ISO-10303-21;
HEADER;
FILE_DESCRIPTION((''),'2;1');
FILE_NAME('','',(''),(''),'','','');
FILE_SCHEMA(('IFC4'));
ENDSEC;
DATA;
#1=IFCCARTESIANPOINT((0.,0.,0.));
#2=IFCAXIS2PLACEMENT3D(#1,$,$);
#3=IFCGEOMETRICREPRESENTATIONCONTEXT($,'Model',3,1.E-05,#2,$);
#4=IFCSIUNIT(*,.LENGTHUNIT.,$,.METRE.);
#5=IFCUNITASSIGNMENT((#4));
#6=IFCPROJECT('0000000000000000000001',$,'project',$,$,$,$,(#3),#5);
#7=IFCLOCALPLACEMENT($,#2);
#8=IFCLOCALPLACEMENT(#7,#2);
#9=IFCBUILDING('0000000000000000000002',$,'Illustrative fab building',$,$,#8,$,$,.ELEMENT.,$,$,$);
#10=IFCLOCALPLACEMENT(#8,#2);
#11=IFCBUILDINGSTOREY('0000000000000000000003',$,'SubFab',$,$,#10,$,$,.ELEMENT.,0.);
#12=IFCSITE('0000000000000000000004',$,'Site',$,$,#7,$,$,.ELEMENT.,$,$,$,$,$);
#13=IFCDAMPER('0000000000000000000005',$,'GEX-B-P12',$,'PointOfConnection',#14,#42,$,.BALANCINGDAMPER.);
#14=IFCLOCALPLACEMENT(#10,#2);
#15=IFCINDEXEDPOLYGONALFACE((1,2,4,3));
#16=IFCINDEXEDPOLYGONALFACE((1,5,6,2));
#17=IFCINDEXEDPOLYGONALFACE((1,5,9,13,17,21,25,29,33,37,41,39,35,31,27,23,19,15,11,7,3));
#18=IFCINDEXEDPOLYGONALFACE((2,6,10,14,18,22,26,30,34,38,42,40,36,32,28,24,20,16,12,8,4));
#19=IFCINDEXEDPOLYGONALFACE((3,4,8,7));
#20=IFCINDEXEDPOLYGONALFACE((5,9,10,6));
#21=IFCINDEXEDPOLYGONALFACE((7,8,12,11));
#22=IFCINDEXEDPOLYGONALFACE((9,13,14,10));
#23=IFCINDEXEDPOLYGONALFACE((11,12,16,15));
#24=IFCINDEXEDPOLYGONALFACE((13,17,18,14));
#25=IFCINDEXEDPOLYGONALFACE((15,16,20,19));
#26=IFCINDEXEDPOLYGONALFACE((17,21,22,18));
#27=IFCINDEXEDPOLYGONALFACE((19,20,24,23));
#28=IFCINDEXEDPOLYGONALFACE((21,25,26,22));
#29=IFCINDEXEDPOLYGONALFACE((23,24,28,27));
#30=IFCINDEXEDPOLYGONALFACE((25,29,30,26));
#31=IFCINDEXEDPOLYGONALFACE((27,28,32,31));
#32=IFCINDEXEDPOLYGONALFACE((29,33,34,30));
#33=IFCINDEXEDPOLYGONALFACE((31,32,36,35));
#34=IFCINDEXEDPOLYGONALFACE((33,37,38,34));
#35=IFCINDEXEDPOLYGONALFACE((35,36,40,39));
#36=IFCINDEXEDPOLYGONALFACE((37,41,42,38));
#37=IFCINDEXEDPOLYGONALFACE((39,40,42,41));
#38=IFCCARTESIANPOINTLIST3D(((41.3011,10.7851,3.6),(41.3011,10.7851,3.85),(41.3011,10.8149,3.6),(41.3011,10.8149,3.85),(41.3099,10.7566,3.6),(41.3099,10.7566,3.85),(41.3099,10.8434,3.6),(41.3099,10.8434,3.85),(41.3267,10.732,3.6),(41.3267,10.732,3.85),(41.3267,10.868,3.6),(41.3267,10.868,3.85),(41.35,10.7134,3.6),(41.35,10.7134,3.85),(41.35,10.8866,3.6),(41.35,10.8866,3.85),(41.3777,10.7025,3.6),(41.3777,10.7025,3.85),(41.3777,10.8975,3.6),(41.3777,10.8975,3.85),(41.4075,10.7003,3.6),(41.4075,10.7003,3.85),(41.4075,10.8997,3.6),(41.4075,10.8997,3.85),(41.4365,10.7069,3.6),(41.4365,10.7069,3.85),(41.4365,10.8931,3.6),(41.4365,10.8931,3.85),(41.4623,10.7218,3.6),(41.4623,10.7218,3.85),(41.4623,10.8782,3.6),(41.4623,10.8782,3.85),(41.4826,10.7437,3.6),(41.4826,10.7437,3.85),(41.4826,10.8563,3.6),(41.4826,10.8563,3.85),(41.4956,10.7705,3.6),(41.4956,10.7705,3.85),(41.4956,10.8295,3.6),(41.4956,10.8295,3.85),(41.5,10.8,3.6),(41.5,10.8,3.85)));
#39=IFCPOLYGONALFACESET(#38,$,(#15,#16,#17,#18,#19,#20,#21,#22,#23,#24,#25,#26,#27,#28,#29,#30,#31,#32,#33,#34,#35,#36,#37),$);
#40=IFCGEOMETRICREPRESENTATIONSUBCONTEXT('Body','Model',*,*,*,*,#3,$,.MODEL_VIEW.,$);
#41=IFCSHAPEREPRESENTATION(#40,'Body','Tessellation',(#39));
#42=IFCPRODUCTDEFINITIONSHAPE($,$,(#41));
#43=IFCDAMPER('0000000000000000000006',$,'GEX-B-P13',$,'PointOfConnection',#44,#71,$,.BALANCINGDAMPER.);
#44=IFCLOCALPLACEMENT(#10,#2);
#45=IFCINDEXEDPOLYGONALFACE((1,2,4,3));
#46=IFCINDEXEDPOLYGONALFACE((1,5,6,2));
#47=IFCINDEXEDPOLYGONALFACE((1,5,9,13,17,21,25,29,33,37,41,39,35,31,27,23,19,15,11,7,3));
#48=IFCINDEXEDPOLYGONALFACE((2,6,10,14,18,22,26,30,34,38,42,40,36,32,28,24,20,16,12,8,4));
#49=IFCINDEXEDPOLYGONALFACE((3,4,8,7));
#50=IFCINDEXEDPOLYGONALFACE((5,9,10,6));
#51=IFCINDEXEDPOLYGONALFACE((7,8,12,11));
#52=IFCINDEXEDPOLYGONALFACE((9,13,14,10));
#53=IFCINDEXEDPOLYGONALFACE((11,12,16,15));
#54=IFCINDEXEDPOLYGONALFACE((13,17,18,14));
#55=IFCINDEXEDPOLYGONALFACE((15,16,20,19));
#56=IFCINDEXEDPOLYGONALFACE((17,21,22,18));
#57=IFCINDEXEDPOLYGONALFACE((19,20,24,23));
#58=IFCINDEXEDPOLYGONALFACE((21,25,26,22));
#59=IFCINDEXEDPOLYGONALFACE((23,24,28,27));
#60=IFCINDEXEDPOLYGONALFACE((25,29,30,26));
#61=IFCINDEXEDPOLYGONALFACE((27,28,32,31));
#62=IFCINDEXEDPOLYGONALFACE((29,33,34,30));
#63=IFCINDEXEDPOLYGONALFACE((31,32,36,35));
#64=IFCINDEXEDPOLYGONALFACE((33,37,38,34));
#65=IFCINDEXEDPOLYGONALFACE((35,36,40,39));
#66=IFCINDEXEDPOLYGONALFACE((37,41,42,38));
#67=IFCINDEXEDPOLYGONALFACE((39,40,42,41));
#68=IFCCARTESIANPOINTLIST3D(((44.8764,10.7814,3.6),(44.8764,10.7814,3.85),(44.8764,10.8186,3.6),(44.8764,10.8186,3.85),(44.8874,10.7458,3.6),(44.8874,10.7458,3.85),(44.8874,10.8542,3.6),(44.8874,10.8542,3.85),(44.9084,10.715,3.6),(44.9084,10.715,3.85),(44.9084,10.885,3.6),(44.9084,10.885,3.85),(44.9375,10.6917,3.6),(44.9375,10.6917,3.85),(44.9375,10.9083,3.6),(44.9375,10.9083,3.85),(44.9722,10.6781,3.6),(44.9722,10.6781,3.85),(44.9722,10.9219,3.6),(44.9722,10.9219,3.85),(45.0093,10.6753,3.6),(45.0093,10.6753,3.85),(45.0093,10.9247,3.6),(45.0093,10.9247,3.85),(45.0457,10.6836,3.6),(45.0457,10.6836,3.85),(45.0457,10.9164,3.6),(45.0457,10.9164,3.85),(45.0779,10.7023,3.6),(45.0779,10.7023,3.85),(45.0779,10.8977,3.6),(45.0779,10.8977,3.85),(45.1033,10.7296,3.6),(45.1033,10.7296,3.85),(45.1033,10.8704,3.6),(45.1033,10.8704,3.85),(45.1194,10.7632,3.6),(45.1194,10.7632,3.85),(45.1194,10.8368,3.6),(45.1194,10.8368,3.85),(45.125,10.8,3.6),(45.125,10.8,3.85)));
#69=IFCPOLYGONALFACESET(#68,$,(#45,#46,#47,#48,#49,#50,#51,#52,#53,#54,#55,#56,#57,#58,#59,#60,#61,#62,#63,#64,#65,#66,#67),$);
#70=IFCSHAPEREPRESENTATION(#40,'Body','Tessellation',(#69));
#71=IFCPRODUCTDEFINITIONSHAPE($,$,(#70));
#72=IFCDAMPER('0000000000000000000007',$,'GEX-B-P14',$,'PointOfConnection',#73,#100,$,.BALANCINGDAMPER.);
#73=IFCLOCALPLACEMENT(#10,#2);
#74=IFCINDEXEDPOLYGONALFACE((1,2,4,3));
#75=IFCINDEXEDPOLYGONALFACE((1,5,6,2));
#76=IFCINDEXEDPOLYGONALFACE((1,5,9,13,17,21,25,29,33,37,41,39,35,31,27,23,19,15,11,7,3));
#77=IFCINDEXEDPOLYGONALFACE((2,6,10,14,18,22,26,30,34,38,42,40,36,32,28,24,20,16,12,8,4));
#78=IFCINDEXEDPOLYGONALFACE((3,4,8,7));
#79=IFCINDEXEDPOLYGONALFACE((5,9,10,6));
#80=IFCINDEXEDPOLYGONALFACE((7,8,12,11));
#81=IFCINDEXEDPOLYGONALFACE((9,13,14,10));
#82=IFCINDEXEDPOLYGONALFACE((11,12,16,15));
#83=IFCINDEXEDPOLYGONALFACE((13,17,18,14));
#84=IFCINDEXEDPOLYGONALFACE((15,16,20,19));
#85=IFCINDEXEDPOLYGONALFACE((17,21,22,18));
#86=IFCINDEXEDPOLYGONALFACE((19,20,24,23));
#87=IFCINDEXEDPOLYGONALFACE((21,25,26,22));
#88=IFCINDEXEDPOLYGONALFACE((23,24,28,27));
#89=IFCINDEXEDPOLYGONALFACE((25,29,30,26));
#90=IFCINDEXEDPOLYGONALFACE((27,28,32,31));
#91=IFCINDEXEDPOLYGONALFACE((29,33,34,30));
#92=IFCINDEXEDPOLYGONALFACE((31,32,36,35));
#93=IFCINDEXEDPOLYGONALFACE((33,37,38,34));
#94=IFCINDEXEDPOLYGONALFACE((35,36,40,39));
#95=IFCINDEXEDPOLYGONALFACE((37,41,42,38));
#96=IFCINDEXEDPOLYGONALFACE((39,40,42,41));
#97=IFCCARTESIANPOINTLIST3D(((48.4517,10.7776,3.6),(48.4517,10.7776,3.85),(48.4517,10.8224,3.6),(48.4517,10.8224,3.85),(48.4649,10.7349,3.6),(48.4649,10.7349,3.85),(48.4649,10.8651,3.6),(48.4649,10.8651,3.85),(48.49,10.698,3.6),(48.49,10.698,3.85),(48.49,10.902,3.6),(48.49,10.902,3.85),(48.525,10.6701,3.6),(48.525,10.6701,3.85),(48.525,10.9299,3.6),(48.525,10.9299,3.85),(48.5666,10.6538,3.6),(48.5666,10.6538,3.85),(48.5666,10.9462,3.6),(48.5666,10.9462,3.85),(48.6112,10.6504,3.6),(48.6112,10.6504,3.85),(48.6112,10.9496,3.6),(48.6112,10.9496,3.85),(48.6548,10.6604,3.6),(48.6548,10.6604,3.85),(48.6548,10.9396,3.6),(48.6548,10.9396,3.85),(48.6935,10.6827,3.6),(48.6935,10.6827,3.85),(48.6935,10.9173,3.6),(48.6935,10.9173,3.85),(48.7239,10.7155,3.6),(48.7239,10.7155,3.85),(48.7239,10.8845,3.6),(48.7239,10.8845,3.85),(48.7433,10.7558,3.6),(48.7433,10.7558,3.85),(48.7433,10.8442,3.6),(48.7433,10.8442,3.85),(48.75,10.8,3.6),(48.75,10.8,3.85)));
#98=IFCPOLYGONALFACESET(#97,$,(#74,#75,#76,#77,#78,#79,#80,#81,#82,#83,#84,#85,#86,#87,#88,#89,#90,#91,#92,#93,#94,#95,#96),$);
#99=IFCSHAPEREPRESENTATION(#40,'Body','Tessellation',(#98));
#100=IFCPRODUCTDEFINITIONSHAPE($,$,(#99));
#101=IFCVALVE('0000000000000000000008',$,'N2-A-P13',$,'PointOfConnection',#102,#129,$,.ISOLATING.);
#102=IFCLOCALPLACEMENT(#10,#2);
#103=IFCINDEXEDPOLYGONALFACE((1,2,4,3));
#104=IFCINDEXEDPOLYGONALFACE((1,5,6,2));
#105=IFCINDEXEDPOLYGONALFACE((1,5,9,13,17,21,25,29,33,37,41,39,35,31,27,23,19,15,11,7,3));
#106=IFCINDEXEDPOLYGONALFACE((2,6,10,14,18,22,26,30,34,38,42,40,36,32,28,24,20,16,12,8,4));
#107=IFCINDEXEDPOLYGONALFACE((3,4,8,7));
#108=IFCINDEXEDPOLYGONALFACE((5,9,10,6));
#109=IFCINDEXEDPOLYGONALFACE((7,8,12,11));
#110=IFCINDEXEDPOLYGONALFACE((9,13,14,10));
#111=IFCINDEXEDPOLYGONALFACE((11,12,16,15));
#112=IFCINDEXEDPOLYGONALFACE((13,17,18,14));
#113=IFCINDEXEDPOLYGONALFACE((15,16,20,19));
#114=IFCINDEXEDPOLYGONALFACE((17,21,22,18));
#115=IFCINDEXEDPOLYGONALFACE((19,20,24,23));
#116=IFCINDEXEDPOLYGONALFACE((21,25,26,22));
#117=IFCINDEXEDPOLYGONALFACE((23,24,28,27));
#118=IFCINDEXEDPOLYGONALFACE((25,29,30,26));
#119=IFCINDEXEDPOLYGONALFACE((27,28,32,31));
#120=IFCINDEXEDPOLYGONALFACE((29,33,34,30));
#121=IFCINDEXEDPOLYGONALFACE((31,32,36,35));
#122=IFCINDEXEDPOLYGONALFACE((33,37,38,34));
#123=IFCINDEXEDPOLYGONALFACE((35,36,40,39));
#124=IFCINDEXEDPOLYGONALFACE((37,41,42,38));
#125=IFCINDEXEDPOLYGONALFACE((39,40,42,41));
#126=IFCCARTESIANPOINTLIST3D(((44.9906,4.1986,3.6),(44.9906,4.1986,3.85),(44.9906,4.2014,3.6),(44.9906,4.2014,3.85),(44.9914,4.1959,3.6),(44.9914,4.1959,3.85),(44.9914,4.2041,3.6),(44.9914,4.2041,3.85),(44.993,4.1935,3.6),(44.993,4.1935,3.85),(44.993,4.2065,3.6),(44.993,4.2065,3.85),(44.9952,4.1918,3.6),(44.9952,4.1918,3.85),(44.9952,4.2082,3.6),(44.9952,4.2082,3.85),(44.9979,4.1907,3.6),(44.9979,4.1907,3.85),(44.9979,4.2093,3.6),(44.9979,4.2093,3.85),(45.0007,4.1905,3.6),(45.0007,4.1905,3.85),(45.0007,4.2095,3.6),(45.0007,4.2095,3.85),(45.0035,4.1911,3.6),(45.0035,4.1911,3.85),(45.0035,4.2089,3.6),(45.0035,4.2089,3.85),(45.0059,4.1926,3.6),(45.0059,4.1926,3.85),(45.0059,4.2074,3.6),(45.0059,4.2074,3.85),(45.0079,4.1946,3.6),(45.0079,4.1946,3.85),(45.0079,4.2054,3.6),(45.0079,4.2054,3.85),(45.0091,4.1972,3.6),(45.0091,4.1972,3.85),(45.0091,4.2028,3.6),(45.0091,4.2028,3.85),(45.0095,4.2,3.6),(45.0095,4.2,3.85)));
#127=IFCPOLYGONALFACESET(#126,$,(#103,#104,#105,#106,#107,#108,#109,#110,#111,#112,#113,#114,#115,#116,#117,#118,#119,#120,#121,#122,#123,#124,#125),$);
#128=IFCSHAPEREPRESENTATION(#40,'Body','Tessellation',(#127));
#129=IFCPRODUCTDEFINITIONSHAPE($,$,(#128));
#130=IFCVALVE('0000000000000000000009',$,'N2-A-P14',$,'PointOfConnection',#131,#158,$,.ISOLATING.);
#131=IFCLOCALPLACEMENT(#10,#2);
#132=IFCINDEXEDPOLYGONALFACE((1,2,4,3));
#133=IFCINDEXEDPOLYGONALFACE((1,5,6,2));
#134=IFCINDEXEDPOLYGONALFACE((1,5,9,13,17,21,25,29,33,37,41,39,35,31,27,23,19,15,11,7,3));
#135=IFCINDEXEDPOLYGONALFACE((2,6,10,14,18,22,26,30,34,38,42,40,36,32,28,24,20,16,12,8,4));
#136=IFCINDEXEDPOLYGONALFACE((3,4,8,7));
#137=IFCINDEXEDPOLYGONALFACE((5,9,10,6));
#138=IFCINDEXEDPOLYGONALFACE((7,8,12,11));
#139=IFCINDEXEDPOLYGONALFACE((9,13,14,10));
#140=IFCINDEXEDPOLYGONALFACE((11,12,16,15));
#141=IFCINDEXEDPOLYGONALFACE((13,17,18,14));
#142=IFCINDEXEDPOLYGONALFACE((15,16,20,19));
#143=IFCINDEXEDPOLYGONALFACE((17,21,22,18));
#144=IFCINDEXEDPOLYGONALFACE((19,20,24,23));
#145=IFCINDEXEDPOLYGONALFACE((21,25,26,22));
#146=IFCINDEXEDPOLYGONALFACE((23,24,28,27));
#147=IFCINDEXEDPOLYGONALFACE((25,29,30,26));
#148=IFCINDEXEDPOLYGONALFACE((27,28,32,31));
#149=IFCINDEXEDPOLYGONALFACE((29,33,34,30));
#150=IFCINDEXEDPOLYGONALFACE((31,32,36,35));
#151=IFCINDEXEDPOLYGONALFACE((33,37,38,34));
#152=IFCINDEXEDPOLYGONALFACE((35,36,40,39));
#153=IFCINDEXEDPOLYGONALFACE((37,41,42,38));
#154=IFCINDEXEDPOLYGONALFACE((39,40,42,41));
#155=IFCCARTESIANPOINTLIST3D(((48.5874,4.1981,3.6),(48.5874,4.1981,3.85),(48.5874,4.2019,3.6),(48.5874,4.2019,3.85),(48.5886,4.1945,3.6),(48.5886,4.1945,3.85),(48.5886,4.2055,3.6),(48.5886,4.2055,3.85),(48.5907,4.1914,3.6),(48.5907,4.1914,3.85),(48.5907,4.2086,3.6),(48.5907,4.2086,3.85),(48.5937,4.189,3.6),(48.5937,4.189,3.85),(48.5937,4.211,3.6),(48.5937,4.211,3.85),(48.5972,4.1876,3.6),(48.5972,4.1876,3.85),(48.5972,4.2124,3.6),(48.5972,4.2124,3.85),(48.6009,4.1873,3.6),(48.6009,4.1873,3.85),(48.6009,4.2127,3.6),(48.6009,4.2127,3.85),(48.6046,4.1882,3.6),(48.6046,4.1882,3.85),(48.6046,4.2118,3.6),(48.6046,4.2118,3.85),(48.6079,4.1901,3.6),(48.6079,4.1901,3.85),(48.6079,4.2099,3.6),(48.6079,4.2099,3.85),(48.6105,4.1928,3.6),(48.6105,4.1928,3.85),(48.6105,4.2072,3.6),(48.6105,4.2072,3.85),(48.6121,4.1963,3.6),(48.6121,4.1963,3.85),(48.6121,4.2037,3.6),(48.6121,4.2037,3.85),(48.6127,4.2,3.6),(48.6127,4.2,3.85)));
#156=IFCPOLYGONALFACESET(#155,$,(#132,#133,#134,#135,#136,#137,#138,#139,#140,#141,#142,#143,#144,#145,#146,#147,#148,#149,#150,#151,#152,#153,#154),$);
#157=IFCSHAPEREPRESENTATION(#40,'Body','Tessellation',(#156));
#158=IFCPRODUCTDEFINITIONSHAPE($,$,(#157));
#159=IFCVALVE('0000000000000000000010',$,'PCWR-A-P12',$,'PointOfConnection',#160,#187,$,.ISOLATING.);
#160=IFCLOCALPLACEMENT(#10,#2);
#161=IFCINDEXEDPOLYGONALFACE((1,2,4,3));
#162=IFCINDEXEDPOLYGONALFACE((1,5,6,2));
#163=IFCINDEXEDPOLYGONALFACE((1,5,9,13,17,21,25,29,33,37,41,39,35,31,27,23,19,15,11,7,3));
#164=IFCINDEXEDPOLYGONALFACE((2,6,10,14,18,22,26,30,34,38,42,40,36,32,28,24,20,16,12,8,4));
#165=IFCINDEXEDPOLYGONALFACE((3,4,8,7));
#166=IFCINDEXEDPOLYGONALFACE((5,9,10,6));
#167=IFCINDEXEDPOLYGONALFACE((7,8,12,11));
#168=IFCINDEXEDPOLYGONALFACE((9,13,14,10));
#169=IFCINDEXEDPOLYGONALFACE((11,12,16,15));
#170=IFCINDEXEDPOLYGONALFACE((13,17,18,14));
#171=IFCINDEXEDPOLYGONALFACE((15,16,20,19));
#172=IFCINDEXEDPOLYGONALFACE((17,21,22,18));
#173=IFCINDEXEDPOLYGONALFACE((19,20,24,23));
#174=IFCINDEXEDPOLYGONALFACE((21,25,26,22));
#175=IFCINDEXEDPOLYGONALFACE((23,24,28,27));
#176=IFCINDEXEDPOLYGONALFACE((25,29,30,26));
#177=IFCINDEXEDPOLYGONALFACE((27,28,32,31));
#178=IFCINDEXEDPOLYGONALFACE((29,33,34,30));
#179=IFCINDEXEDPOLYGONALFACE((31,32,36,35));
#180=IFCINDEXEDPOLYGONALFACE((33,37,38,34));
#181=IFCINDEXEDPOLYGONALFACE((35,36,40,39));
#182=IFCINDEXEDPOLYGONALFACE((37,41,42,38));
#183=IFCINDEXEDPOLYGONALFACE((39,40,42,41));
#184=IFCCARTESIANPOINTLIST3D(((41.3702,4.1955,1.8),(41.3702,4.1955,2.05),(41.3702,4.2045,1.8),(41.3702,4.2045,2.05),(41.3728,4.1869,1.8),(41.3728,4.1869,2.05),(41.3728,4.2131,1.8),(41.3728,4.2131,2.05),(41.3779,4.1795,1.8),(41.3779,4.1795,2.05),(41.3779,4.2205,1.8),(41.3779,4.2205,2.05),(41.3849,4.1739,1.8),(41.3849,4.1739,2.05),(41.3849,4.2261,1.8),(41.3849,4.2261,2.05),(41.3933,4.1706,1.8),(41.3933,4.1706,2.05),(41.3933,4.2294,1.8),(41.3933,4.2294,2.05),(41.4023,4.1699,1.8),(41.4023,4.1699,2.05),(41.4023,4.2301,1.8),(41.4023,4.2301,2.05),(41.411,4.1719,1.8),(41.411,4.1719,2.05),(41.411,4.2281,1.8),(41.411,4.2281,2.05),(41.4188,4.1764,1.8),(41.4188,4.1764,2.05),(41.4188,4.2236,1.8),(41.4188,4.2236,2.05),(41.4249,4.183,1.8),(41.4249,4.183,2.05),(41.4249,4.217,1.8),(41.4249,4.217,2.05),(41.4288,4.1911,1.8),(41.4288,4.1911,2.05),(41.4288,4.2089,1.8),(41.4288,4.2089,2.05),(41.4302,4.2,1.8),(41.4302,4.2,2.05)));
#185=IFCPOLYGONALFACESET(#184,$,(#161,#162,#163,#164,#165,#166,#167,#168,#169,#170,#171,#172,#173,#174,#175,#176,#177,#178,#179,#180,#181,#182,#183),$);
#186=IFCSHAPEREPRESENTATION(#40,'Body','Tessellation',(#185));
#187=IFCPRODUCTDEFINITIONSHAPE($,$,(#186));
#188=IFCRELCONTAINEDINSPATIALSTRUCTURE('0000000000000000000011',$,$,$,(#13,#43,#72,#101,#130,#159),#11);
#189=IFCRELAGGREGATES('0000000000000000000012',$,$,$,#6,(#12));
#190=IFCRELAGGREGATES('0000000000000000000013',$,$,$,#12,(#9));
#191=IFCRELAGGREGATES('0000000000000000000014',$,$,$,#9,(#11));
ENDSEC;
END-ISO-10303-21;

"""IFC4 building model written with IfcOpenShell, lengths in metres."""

from ifc_helpers import new_model, entity, si_unit, frame, origin, place, context, subcontext, project, spatial, element, save


model = new_model("IFC4")

# Units and contexts
model_context = context("Model", 3, precision=1e-05, world=origin())
body_context = subcontext(model_context, "Body", "Model", "MODEL_VIEW")
ifc_project = project(units=[si_unit("LENGTHUNIT", "METRE")], contexts=[model_context])

# Site, building, storey
site_placement = place(None, origin())
site = spatial("IfcSite", under=ifc_project, at=site_placement, Name="Site", CompositionType="ELEMENT")
building_placement = place(site_placement, origin())
building = spatial("IfcBuilding", under=site, at=building_placement, Name="Illustrative fab building", CompositionType="ELEMENT")
storey_placement = place(building_placement, origin())
storey = spatial("IfcBuildingStorey", under=building, at=storey_placement, Name="SubFab", CompositionType="ELEMENT", Elevation=0.0)

# Dampers
damper_1_placement = place(storey_placement, frame((41.4, 10.8, 3.6)))
element("IfcDamper", 1, at=damper_1_placement, inside=storey, Name="GEX-B-P12", ObjectType="PointOfConnection", PredefinedType="BALANCINGDAMPER", context=body_context, shape_type="AdvancedSweptSolid", body=[
    entity("IfcSweptDiskSolid", entity("IfcPolyline", [entity("IfcCartesianPoint", [0.0, 0.0, 0.0]), entity("IfcCartesianPoint", [0.0, 0.0, 0.25])]), 0.1),
])
damper_2_placement = place(storey_placement, frame((45.0, 10.8, 3.6)))
element("IfcDamper", 2, at=damper_2_placement, inside=storey, Name="GEX-B-P13", ObjectType="PointOfConnection", PredefinedType="BALANCINGDAMPER", context=body_context, shape_type="AdvancedSweptSolid", body=[
    entity("IfcSweptDiskSolid", entity("IfcPolyline", [entity("IfcCartesianPoint", [0.0, 0.0, 0.0]), entity("IfcCartesianPoint", [0.0, 0.0, 0.25])]), 0.125),
])
damper_3_placement = place(storey_placement, frame((48.6, 10.8, 3.6)))
element("IfcDamper", 3, at=damper_3_placement, inside=storey, Name="GEX-B-P14", ObjectType="PointOfConnection", PredefinedType="BALANCINGDAMPER", context=body_context, shape_type="AdvancedSweptSolid", body=[
    entity("IfcSweptDiskSolid", entity("IfcPolyline", [entity("IfcCartesianPoint", [0.0, 0.0, 0.0]), entity("IfcCartesianPoint", [0.0, 0.0, 0.25])]), 0.15),
])

# Valves
valve_1_placement = place(storey_placement, frame((45.0, 4.2, 3.6)))
element("IfcValve", 4, at=valve_1_placement, inside=storey, Name="N2-A-P13", ObjectType="PointOfConnection", PredefinedType="ISOLATING", context=body_context, shape_type="AdvancedSweptSolid", body=[
    entity("IfcSweptDiskSolid", entity("IfcPolyline", [entity("IfcCartesianPoint", [0.0, 0.0, 0.0]), entity("IfcCartesianPoint", [0.0, 0.0, 0.25])]), 0.0095),
])
valve_2_placement = place(storey_placement, frame((48.6, 4.2, 3.6)))
element("IfcValve", 5, at=valve_2_placement, inside=storey, Name="N2-A-P14", ObjectType="PointOfConnection", PredefinedType="ISOLATING", context=body_context, shape_type="AdvancedSweptSolid", body=[
    entity("IfcSweptDiskSolid", entity("IfcPolyline", [entity("IfcCartesianPoint", [0.0, 0.0, 0.0]), entity("IfcCartesianPoint", [0.0, 0.0, 0.25])]), 0.0127),
])
valve_3_placement = place(storey_placement, frame((41.4, 4.2, 1.8)))
element("IfcValve", 6, at=valve_3_placement, inside=storey, Name="PCWR-A-P12", ObjectType="PointOfConnection", PredefinedType="ISOLATING", context=body_context, shape_type="AdvancedSweptSolid", body=[
    entity("IfcSweptDiskSolid", entity("IfcPolyline", [entity("IfcCartesianPoint", [0.0, 0.0, 0.0]), entity("IfcCartesianPoint", [0.0, 0.0, 0.25])]), 0.0302),
])

save(model, "model.ifc")
